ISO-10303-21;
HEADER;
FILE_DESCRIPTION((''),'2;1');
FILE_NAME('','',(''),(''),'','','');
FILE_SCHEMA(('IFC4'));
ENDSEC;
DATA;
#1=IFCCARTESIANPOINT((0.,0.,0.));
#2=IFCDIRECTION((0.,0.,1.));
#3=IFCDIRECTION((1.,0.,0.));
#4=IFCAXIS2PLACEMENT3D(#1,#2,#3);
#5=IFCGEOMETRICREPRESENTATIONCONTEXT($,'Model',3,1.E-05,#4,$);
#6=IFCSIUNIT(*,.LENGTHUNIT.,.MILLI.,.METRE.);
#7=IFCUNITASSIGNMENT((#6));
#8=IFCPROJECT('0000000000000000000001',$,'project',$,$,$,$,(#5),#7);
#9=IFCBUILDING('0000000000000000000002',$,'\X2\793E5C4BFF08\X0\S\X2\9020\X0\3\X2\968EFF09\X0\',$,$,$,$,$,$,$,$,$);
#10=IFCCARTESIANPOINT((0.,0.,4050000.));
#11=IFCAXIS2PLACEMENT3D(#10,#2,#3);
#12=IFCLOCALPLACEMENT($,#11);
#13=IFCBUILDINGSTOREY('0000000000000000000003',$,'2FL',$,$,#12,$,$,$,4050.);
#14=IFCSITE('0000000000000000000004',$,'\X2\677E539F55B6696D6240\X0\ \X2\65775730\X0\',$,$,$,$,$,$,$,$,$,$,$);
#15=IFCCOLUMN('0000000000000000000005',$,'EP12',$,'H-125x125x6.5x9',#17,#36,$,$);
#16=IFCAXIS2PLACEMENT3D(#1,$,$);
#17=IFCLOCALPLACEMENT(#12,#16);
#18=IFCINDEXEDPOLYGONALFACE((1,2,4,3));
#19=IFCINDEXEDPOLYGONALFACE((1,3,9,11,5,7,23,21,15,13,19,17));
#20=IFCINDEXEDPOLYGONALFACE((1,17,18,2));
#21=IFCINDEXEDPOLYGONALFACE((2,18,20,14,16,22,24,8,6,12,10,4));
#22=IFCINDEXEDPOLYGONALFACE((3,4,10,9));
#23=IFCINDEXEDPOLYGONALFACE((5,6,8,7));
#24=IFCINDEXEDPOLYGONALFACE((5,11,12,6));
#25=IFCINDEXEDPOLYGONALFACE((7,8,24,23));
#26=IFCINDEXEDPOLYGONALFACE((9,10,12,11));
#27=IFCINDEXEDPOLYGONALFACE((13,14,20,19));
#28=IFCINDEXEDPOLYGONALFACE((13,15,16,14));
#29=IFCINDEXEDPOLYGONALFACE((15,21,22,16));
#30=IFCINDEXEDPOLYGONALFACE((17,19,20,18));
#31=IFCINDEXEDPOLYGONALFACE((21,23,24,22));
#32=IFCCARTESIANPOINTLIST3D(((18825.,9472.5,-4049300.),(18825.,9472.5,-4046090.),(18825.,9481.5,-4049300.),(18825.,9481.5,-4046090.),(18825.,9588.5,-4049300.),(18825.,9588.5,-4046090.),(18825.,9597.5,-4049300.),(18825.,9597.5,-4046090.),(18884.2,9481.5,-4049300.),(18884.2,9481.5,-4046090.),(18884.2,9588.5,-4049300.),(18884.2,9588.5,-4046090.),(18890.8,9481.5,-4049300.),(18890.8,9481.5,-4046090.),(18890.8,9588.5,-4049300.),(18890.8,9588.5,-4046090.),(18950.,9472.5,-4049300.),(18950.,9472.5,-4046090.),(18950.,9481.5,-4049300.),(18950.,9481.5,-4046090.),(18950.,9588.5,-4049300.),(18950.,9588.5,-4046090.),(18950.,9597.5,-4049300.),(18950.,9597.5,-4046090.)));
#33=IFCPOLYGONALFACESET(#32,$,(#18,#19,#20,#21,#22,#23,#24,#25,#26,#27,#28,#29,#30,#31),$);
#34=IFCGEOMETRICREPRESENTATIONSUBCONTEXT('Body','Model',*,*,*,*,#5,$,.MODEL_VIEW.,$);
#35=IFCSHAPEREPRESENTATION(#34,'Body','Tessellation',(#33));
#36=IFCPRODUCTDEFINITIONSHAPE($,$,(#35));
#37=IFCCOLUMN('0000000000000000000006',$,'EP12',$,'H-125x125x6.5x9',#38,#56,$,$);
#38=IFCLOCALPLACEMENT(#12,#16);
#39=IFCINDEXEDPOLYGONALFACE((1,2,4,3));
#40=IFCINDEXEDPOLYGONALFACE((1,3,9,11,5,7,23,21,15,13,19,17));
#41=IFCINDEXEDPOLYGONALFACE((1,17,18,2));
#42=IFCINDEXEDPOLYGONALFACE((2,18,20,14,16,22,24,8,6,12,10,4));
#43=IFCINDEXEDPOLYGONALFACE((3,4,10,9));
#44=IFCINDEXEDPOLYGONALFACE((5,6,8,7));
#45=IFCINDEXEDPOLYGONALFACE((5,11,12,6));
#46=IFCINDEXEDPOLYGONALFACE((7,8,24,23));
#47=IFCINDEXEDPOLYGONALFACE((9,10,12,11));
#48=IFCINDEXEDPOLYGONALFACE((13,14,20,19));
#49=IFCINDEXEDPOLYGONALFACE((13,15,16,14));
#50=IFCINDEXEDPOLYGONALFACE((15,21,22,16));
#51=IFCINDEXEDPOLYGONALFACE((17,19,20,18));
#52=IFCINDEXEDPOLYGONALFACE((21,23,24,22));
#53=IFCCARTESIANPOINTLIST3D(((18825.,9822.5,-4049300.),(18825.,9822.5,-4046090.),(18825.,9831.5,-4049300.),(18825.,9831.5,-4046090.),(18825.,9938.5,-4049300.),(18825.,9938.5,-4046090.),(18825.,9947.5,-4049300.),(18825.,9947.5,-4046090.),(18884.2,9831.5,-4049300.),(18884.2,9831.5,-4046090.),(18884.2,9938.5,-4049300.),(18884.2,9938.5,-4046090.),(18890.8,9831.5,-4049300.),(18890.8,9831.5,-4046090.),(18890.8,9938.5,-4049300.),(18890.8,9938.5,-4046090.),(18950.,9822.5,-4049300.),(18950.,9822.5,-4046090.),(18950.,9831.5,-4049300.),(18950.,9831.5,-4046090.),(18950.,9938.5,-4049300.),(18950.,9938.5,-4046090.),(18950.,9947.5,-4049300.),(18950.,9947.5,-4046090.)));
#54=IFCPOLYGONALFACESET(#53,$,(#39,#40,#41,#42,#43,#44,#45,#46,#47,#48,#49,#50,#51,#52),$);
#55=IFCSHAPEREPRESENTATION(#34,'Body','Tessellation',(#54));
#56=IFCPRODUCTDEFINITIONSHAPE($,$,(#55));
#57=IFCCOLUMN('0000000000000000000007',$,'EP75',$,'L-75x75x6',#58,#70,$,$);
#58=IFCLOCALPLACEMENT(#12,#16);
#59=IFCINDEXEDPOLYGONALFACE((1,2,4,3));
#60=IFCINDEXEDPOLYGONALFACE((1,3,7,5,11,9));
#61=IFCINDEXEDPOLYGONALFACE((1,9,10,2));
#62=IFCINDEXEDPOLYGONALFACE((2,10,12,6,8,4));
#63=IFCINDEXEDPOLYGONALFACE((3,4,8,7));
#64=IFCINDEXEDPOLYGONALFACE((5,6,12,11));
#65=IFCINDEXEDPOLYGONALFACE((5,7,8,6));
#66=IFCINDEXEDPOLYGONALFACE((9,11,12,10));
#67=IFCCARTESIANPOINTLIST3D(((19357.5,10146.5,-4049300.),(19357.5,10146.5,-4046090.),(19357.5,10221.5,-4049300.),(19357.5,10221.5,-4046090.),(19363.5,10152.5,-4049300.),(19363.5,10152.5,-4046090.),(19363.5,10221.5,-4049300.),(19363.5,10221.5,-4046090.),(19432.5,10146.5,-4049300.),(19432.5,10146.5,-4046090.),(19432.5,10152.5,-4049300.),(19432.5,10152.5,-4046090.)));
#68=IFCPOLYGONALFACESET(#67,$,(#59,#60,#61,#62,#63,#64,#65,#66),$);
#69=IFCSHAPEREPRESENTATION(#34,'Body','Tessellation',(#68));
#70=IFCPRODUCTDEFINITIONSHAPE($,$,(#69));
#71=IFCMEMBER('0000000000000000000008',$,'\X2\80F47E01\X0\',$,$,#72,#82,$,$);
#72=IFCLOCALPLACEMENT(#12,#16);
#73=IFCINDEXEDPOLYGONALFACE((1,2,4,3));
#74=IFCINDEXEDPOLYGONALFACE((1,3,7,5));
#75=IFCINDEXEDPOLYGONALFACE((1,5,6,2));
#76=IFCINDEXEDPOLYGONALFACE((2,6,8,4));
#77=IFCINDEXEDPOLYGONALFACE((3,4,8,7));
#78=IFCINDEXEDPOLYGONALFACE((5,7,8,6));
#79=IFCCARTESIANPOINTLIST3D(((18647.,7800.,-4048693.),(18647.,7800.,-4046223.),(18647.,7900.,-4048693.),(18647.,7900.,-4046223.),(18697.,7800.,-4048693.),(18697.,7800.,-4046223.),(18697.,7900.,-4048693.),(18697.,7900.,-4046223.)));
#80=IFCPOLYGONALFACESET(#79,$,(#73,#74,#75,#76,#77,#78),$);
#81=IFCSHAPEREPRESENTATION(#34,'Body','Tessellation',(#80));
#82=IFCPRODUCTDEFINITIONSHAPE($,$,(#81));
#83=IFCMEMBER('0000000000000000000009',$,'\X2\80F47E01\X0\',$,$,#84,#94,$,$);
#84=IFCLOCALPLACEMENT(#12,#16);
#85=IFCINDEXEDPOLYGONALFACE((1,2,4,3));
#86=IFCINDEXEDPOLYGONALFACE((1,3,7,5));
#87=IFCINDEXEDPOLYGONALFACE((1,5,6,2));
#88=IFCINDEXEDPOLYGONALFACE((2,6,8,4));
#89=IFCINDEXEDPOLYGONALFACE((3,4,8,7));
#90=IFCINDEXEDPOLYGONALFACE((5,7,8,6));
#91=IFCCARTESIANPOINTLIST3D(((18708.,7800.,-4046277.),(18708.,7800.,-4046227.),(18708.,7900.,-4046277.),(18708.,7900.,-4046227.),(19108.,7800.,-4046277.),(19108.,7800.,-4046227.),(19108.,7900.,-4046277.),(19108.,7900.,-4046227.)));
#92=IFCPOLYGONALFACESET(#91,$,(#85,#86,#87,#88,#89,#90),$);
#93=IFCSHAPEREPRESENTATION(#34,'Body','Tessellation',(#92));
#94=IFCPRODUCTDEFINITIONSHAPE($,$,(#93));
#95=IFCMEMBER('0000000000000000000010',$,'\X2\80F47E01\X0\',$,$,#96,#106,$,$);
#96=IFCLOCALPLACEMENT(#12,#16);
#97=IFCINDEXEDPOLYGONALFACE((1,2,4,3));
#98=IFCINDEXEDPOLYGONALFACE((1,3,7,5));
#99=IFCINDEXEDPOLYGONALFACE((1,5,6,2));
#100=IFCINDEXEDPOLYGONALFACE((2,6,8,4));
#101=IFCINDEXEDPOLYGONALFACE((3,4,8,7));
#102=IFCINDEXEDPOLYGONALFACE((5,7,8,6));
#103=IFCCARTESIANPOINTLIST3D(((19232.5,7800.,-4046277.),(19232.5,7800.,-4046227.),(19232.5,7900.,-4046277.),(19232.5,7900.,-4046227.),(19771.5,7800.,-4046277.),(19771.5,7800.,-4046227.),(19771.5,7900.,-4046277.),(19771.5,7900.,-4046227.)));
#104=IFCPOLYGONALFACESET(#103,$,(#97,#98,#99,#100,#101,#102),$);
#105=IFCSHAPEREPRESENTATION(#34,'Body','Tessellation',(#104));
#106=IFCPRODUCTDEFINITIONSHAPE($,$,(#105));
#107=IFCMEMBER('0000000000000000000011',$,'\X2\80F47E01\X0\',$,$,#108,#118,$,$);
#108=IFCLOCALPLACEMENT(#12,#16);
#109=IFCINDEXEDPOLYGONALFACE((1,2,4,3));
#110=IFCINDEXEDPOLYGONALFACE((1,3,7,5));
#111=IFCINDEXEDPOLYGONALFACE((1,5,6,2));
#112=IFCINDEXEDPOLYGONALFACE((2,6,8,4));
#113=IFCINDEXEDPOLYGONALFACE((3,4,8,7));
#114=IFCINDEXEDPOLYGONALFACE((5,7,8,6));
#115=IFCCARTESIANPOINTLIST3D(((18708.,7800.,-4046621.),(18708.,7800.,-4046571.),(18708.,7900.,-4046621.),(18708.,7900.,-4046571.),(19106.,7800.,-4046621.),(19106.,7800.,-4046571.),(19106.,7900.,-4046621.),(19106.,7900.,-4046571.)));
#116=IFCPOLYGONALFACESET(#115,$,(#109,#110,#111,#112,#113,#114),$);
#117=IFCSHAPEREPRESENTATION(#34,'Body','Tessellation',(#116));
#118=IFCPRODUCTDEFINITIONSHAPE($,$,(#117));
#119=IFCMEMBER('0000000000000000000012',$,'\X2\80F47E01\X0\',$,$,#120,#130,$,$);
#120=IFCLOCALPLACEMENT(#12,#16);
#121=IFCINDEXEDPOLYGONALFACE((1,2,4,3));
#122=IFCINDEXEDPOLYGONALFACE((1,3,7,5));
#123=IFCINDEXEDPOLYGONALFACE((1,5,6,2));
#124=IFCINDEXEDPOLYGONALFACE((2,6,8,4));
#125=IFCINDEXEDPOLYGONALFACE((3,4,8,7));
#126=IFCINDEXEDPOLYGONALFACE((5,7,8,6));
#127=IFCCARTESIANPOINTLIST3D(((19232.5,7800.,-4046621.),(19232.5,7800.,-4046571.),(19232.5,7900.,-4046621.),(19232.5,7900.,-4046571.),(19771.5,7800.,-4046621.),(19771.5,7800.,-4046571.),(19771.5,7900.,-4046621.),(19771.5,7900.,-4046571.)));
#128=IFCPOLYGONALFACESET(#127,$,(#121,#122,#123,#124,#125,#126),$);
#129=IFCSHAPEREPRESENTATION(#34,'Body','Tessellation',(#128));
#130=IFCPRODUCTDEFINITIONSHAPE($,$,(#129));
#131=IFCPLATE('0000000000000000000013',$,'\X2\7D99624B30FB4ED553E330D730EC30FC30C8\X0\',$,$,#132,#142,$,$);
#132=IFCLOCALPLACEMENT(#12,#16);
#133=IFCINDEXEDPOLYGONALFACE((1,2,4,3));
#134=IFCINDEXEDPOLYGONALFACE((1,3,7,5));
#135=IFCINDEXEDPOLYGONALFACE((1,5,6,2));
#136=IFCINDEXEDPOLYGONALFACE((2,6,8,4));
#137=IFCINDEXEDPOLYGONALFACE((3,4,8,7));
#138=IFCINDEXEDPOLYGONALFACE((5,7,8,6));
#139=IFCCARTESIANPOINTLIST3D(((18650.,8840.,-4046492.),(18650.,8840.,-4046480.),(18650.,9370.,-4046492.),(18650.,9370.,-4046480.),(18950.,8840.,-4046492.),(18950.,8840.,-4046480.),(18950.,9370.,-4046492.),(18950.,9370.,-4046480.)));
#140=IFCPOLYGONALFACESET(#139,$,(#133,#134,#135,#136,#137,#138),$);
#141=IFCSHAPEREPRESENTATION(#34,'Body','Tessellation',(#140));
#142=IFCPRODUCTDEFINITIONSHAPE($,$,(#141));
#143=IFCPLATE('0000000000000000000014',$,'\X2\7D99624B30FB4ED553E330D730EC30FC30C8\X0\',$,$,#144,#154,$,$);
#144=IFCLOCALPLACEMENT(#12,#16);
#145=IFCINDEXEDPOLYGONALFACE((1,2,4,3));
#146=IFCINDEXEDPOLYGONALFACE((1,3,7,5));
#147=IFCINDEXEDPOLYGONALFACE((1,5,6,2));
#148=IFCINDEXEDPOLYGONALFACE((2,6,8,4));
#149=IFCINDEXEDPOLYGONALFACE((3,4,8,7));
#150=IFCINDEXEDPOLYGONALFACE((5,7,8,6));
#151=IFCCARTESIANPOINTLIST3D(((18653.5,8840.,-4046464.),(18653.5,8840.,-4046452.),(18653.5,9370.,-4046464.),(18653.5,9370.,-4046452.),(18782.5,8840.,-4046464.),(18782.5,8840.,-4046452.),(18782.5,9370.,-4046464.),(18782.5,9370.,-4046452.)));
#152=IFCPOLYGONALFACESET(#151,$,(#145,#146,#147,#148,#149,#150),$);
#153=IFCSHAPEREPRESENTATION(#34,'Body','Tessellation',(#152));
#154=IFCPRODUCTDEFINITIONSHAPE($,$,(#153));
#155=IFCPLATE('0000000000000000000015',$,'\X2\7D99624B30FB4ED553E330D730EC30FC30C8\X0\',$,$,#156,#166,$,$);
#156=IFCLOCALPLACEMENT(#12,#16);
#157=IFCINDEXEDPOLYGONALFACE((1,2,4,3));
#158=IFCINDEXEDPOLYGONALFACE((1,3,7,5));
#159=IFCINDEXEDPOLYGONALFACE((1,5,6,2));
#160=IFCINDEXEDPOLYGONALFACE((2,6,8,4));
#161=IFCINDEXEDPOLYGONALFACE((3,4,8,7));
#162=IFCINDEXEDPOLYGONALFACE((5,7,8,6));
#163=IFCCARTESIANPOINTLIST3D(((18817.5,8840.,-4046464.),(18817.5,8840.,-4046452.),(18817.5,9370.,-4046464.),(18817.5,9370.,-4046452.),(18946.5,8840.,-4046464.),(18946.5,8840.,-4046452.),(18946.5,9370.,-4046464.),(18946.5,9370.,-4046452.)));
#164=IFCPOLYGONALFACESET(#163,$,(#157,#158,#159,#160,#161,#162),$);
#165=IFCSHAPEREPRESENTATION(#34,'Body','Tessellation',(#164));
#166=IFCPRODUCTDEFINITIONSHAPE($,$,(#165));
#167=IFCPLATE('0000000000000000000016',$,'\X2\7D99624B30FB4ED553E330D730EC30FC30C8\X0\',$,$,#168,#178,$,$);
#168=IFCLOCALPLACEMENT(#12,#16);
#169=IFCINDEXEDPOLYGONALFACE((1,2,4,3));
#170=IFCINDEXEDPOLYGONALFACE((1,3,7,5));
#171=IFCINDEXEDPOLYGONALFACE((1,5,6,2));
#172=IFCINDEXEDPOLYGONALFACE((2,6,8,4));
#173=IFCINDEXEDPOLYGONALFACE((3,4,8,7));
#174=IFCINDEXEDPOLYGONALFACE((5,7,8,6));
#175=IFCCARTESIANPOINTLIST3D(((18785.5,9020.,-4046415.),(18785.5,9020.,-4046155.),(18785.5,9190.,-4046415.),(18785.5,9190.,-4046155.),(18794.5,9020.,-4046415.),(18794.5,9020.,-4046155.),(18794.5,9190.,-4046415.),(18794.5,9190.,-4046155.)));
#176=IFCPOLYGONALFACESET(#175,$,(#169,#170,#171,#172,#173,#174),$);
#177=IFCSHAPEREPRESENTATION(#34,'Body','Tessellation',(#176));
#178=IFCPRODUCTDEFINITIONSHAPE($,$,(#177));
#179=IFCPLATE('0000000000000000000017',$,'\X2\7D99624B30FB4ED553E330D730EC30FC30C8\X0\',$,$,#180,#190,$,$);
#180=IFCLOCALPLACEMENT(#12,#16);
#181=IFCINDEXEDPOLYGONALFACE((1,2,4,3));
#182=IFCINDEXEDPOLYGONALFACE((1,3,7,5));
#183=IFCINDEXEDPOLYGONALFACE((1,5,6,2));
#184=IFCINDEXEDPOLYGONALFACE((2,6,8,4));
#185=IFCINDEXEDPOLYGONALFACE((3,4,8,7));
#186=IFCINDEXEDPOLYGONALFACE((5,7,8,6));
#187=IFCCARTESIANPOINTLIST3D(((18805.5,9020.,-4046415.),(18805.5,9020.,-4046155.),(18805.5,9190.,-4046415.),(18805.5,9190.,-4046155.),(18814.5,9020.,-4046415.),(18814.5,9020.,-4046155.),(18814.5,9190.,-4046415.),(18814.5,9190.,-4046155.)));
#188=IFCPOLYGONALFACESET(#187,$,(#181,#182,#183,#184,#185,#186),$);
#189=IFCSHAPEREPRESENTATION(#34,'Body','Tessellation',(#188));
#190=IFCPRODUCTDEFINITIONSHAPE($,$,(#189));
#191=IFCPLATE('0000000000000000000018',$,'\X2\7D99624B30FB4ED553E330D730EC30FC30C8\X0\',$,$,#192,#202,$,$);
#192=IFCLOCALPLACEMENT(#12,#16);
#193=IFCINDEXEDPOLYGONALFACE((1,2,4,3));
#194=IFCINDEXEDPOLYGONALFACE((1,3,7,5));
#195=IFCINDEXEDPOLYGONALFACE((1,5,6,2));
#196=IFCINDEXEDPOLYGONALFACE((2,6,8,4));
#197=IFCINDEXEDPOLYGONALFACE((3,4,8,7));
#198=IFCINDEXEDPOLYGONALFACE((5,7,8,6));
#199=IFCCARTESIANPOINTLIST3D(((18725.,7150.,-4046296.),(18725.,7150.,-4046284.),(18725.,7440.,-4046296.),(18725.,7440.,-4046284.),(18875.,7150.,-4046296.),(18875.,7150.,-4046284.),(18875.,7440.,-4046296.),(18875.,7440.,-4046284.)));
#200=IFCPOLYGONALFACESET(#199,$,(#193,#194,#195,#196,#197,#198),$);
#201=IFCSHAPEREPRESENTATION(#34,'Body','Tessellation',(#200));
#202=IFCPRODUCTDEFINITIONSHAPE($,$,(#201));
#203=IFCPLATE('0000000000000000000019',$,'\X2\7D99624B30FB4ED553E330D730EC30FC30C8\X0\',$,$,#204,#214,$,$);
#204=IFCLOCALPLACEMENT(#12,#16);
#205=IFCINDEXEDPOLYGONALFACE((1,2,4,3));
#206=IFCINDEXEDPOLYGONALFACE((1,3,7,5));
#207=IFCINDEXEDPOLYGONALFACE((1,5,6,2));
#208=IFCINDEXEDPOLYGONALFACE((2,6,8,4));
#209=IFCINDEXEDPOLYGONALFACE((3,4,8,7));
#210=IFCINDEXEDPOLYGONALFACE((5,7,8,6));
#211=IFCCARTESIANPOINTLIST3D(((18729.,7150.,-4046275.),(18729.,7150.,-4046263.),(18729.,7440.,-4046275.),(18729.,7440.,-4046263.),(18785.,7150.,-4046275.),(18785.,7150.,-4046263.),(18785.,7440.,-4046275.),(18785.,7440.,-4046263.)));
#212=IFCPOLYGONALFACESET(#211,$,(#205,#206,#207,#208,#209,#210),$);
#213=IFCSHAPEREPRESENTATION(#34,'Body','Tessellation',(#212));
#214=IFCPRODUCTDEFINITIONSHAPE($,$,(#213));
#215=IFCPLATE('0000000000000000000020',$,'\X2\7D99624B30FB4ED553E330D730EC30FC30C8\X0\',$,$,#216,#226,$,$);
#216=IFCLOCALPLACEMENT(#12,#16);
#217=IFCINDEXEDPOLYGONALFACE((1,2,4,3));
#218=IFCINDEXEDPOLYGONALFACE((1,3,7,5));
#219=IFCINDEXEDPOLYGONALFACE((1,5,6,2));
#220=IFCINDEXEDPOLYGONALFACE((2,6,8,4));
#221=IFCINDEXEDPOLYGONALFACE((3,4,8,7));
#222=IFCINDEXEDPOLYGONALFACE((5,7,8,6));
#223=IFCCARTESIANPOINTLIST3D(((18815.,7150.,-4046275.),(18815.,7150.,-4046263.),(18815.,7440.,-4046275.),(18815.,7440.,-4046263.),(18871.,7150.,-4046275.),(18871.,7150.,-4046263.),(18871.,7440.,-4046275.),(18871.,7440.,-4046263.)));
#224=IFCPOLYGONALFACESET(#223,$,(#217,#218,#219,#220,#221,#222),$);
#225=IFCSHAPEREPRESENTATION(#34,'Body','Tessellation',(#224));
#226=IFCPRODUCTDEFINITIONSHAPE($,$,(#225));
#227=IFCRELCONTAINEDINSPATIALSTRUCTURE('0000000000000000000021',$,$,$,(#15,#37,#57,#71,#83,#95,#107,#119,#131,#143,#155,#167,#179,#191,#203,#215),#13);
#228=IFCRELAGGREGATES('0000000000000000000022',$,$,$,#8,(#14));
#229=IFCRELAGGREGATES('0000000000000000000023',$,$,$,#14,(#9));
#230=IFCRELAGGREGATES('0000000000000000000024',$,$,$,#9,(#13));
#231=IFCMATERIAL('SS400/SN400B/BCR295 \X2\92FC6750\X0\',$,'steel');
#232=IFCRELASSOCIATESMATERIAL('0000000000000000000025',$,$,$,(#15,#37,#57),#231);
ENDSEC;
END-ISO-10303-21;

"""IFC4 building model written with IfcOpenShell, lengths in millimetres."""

from ifc_helpers import new_model, si_unit, frame, origin, origin_with_axes, place, context, subcontext, project, spatial, rectangle, i_section, l_section, extrude, material, element, save


model = new_model("IFC4")

# Units and contexts
model_context = context("Model", 3, precision=1e-05, world=origin_with_axes())
body_context = subcontext(model_context, "Body", "Model", "MODEL_VIEW")
ifc_project = project(units=[si_unit("LENGTHUNIT", "METRE", prefix="MILLI")], contexts=[model_context])

# Site, building, storey
site = spatial("IfcSite", under=ifc_project, Name="松原営業所 敷地")
building = spatial("IfcBuilding", under=site, Name="社屋（S造3階）")
storey_placement = place(None, frame((0.0, 0.0, 4050000.0), z_axis=(0.0, 0.0, 1.0), x_axis=(1.0, 0.0, 0.0)))
storey = spatial("IfcBuildingStorey", under=building, at=storey_placement, Name="2FL", Elevation=4050.0)

# Columns
ifc_material = material(Name="SS400/SN400B/BCR295 鋼材", Category="steel")
for number, where, z_axis, x_axis, name in (
    (1, (18887.5, 9535.0, -4049300.0), (0.0, 0.0, 1.0), (1.0, 0.0, 0.0), "EP12"),
    (2, (18887.5, 9885.0, -4049300.0), (0.0, 0.0, 1.0), (1.0, 0.0, 0.0), "EP12"),
):
    element("IfcColumn", number, at=place(storey_placement, frame(where, z_axis=z_axis, x_axis=x_axis)), inside=storey, material=ifc_material, Name=name, ObjectType="H-125x125x6.5x9", context=body_context, shape_type="SweptSolid", body=[
        extrude(i_section(OverallWidth=125.0, OverallDepth=125.0, WebThickness=6.5, FlangeThickness=9.0), origin(), (0.0, 0.0, 1.0), 3210.0),
    ])
column_placement = place(storey_placement, frame((19395.0, 10184.0, -4049300.0), z_axis=(0.0, 0.0, 1.0), x_axis=(1.0, 0.0, 0.0)))
element("IfcColumn", 3, at=column_placement, inside=storey, material=ifc_material, Name="EP75", ObjectType="L-75x75x6", context=body_context, shape_type="SweptSolid", body=[
    extrude(l_section(Depth=75.0, Width=75.0, Thickness=6.0), origin(), (0.0, 0.0, 1.0), 3210.0),
])

# Members
member_1_placement = place(storey_placement, frame((18647.0, 7850.0, -4047458.0), z_axis=(1.0, 0.0, 0.0), x_axis=(0.0, 1.0, 0.0)))
element("IfcMember", 4, at=member_1_placement, inside=storey, Name="胴縁", context=body_context, shape_type="SweptSolid", body=[
    extrude(rectangle(XDim=100.0, YDim=2470.0), origin(), (0.0, 0.0, 1.0), 50.0),
])
member_2_placement = place(storey_placement, frame((18708.0, 7850.0, -4046252.0), z_axis=(1.0, 0.0, 0.0), x_axis=(0.0, 1.0, 0.0)))
element("IfcMember", 5, at=member_2_placement, inside=storey, Name="胴縁", context=body_context, shape_type="SweptSolid", body=[
    extrude(rectangle(XDim=100.0, YDim=50.0), origin(), (0.0, 0.0, 1.0), 400.0),
])
member_3_placement = place(storey_placement, frame((19232.5, 7850.0, -4046252.0), z_axis=(1.0, 0.0, 0.0), x_axis=(0.0, 1.0, 0.0)))
element("IfcMember", 6, at=member_3_placement, inside=storey, Name="胴縁", context=body_context, shape_type="SweptSolid", body=[
    extrude(rectangle(XDim=100.0, YDim=50.0), origin(), (0.0, 0.0, 1.0), 539.0),
])
member_4_placement = place(storey_placement, frame((18708.0, 7850.0, -4046596.0), z_axis=(1.0, 0.0, 0.0), x_axis=(0.0, 1.0, 0.0)))
element("IfcMember", 7, at=member_4_placement, inside=storey, Name="胴縁", context=body_context, shape_type="SweptSolid", body=[
    extrude(rectangle(XDim=100.0, YDim=50.0), origin(), (0.0, 0.0, 1.0), 398.0),
])
member_5_placement = place(storey_placement, frame((19232.5, 7850.0, -4046596.0), z_axis=(1.0, 0.0, 0.0), x_axis=(0.0, 1.0, 0.0)))
element("IfcMember", 8, at=member_5_placement, inside=storey, Name="胴縁", context=body_context, shape_type="SweptSolid", body=[
    extrude(rectangle(XDim=100.0, YDim=50.0), origin(), (0.0, 0.0, 1.0), 539.0),
])

# Plates
plate_1_placement = place(storey_placement, frame((18800.0, 8840.0, -4046486.0), z_axis=(0.0, 1.0, 0.0), x_axis=(-1.0, 0.0, 0.0)))
element("IfcPlate", 9, at=plate_1_placement, inside=storey, Name="継手・仕口プレート", context=body_context, shape_type="SweptSolid", body=[
    extrude(rectangle(XDim=300.0, YDim=12.0), origin(), (0.0, 0.0, 1.0), 530.0),
])
for number, where, z_axis, x_axis, name in (
    (10, (18718.0, 8840.0, -4046458.0), (0.0, 1.0, 0.0), (-1.0, 0.0, 0.0), "継手・仕口プレート"),
    (11, (18882.0, 8840.0, -4046458.0), (0.0, 1.0, 0.0), (-1.0, 0.0, 0.0), "継手・仕口プレート"),
):
    element("IfcPlate", number, at=place(storey_placement, frame(where, z_axis=z_axis, x_axis=x_axis)), inside=storey, Name=name, context=body_context, shape_type="SweptSolid", body=[
        extrude(rectangle(XDim=129.0, YDim=12.0), origin(), (0.0, 0.0, 1.0), 530.0),
    ])
for number, where, z_axis, x_axis, name in (
    (12, (18790.0, 9020.0, -4046285.0), (0.0, 1.0, 0.0), (-1.0, 0.0, 0.0), "継手・仕口プレート"),
    (13, (18810.0, 9020.0, -4046285.0), (0.0, 1.0, 0.0), (-1.0, 0.0, 0.0), "継手・仕口プレート"),
):
    element("IfcPlate", number, at=place(storey_placement, frame(where, z_axis=z_axis, x_axis=x_axis)), inside=storey, Name=name, context=body_context, shape_type="SweptSolid", body=[
        extrude(rectangle(XDim=9.0, YDim=260.0), origin(), (0.0, 0.0, 1.0), 170.0),
    ])
plate_2_placement = place(storey_placement, frame((18800.0, 7150.0, -4046290.0), z_axis=(0.0, 1.0, 0.0), x_axis=(-1.0, 0.0, 0.0)))
element("IfcPlate", 14, at=plate_2_placement, inside=storey, Name="継手・仕口プレート", context=body_context, shape_type="SweptSolid", body=[
    extrude(rectangle(XDim=150.0, YDim=12.0), origin(), (0.0, 0.0, 1.0), 290.0),
])
for number, where, z_axis, x_axis, name in (
    (15, (18757.0, 7150.0, -4046269.0), (0.0, 1.0, 0.0), (-1.0, 0.0, 0.0), "継手・仕口プレート"),
    (16, (18843.0, 7150.0, -4046269.0), (0.0, 1.0, 0.0), (-1.0, 0.0, 0.0), "継手・仕口プレート"),
):
    element("IfcPlate", number, at=place(storey_placement, frame(where, z_axis=z_axis, x_axis=x_axis)), inside=storey, Name=name, context=body_context, shape_type="SweptSolid", body=[
        extrude(rectangle(XDim=56.0, YDim=12.0), origin(), (0.0, 0.0, 1.0), 290.0),
    ])

save(model, "model.ifc")
